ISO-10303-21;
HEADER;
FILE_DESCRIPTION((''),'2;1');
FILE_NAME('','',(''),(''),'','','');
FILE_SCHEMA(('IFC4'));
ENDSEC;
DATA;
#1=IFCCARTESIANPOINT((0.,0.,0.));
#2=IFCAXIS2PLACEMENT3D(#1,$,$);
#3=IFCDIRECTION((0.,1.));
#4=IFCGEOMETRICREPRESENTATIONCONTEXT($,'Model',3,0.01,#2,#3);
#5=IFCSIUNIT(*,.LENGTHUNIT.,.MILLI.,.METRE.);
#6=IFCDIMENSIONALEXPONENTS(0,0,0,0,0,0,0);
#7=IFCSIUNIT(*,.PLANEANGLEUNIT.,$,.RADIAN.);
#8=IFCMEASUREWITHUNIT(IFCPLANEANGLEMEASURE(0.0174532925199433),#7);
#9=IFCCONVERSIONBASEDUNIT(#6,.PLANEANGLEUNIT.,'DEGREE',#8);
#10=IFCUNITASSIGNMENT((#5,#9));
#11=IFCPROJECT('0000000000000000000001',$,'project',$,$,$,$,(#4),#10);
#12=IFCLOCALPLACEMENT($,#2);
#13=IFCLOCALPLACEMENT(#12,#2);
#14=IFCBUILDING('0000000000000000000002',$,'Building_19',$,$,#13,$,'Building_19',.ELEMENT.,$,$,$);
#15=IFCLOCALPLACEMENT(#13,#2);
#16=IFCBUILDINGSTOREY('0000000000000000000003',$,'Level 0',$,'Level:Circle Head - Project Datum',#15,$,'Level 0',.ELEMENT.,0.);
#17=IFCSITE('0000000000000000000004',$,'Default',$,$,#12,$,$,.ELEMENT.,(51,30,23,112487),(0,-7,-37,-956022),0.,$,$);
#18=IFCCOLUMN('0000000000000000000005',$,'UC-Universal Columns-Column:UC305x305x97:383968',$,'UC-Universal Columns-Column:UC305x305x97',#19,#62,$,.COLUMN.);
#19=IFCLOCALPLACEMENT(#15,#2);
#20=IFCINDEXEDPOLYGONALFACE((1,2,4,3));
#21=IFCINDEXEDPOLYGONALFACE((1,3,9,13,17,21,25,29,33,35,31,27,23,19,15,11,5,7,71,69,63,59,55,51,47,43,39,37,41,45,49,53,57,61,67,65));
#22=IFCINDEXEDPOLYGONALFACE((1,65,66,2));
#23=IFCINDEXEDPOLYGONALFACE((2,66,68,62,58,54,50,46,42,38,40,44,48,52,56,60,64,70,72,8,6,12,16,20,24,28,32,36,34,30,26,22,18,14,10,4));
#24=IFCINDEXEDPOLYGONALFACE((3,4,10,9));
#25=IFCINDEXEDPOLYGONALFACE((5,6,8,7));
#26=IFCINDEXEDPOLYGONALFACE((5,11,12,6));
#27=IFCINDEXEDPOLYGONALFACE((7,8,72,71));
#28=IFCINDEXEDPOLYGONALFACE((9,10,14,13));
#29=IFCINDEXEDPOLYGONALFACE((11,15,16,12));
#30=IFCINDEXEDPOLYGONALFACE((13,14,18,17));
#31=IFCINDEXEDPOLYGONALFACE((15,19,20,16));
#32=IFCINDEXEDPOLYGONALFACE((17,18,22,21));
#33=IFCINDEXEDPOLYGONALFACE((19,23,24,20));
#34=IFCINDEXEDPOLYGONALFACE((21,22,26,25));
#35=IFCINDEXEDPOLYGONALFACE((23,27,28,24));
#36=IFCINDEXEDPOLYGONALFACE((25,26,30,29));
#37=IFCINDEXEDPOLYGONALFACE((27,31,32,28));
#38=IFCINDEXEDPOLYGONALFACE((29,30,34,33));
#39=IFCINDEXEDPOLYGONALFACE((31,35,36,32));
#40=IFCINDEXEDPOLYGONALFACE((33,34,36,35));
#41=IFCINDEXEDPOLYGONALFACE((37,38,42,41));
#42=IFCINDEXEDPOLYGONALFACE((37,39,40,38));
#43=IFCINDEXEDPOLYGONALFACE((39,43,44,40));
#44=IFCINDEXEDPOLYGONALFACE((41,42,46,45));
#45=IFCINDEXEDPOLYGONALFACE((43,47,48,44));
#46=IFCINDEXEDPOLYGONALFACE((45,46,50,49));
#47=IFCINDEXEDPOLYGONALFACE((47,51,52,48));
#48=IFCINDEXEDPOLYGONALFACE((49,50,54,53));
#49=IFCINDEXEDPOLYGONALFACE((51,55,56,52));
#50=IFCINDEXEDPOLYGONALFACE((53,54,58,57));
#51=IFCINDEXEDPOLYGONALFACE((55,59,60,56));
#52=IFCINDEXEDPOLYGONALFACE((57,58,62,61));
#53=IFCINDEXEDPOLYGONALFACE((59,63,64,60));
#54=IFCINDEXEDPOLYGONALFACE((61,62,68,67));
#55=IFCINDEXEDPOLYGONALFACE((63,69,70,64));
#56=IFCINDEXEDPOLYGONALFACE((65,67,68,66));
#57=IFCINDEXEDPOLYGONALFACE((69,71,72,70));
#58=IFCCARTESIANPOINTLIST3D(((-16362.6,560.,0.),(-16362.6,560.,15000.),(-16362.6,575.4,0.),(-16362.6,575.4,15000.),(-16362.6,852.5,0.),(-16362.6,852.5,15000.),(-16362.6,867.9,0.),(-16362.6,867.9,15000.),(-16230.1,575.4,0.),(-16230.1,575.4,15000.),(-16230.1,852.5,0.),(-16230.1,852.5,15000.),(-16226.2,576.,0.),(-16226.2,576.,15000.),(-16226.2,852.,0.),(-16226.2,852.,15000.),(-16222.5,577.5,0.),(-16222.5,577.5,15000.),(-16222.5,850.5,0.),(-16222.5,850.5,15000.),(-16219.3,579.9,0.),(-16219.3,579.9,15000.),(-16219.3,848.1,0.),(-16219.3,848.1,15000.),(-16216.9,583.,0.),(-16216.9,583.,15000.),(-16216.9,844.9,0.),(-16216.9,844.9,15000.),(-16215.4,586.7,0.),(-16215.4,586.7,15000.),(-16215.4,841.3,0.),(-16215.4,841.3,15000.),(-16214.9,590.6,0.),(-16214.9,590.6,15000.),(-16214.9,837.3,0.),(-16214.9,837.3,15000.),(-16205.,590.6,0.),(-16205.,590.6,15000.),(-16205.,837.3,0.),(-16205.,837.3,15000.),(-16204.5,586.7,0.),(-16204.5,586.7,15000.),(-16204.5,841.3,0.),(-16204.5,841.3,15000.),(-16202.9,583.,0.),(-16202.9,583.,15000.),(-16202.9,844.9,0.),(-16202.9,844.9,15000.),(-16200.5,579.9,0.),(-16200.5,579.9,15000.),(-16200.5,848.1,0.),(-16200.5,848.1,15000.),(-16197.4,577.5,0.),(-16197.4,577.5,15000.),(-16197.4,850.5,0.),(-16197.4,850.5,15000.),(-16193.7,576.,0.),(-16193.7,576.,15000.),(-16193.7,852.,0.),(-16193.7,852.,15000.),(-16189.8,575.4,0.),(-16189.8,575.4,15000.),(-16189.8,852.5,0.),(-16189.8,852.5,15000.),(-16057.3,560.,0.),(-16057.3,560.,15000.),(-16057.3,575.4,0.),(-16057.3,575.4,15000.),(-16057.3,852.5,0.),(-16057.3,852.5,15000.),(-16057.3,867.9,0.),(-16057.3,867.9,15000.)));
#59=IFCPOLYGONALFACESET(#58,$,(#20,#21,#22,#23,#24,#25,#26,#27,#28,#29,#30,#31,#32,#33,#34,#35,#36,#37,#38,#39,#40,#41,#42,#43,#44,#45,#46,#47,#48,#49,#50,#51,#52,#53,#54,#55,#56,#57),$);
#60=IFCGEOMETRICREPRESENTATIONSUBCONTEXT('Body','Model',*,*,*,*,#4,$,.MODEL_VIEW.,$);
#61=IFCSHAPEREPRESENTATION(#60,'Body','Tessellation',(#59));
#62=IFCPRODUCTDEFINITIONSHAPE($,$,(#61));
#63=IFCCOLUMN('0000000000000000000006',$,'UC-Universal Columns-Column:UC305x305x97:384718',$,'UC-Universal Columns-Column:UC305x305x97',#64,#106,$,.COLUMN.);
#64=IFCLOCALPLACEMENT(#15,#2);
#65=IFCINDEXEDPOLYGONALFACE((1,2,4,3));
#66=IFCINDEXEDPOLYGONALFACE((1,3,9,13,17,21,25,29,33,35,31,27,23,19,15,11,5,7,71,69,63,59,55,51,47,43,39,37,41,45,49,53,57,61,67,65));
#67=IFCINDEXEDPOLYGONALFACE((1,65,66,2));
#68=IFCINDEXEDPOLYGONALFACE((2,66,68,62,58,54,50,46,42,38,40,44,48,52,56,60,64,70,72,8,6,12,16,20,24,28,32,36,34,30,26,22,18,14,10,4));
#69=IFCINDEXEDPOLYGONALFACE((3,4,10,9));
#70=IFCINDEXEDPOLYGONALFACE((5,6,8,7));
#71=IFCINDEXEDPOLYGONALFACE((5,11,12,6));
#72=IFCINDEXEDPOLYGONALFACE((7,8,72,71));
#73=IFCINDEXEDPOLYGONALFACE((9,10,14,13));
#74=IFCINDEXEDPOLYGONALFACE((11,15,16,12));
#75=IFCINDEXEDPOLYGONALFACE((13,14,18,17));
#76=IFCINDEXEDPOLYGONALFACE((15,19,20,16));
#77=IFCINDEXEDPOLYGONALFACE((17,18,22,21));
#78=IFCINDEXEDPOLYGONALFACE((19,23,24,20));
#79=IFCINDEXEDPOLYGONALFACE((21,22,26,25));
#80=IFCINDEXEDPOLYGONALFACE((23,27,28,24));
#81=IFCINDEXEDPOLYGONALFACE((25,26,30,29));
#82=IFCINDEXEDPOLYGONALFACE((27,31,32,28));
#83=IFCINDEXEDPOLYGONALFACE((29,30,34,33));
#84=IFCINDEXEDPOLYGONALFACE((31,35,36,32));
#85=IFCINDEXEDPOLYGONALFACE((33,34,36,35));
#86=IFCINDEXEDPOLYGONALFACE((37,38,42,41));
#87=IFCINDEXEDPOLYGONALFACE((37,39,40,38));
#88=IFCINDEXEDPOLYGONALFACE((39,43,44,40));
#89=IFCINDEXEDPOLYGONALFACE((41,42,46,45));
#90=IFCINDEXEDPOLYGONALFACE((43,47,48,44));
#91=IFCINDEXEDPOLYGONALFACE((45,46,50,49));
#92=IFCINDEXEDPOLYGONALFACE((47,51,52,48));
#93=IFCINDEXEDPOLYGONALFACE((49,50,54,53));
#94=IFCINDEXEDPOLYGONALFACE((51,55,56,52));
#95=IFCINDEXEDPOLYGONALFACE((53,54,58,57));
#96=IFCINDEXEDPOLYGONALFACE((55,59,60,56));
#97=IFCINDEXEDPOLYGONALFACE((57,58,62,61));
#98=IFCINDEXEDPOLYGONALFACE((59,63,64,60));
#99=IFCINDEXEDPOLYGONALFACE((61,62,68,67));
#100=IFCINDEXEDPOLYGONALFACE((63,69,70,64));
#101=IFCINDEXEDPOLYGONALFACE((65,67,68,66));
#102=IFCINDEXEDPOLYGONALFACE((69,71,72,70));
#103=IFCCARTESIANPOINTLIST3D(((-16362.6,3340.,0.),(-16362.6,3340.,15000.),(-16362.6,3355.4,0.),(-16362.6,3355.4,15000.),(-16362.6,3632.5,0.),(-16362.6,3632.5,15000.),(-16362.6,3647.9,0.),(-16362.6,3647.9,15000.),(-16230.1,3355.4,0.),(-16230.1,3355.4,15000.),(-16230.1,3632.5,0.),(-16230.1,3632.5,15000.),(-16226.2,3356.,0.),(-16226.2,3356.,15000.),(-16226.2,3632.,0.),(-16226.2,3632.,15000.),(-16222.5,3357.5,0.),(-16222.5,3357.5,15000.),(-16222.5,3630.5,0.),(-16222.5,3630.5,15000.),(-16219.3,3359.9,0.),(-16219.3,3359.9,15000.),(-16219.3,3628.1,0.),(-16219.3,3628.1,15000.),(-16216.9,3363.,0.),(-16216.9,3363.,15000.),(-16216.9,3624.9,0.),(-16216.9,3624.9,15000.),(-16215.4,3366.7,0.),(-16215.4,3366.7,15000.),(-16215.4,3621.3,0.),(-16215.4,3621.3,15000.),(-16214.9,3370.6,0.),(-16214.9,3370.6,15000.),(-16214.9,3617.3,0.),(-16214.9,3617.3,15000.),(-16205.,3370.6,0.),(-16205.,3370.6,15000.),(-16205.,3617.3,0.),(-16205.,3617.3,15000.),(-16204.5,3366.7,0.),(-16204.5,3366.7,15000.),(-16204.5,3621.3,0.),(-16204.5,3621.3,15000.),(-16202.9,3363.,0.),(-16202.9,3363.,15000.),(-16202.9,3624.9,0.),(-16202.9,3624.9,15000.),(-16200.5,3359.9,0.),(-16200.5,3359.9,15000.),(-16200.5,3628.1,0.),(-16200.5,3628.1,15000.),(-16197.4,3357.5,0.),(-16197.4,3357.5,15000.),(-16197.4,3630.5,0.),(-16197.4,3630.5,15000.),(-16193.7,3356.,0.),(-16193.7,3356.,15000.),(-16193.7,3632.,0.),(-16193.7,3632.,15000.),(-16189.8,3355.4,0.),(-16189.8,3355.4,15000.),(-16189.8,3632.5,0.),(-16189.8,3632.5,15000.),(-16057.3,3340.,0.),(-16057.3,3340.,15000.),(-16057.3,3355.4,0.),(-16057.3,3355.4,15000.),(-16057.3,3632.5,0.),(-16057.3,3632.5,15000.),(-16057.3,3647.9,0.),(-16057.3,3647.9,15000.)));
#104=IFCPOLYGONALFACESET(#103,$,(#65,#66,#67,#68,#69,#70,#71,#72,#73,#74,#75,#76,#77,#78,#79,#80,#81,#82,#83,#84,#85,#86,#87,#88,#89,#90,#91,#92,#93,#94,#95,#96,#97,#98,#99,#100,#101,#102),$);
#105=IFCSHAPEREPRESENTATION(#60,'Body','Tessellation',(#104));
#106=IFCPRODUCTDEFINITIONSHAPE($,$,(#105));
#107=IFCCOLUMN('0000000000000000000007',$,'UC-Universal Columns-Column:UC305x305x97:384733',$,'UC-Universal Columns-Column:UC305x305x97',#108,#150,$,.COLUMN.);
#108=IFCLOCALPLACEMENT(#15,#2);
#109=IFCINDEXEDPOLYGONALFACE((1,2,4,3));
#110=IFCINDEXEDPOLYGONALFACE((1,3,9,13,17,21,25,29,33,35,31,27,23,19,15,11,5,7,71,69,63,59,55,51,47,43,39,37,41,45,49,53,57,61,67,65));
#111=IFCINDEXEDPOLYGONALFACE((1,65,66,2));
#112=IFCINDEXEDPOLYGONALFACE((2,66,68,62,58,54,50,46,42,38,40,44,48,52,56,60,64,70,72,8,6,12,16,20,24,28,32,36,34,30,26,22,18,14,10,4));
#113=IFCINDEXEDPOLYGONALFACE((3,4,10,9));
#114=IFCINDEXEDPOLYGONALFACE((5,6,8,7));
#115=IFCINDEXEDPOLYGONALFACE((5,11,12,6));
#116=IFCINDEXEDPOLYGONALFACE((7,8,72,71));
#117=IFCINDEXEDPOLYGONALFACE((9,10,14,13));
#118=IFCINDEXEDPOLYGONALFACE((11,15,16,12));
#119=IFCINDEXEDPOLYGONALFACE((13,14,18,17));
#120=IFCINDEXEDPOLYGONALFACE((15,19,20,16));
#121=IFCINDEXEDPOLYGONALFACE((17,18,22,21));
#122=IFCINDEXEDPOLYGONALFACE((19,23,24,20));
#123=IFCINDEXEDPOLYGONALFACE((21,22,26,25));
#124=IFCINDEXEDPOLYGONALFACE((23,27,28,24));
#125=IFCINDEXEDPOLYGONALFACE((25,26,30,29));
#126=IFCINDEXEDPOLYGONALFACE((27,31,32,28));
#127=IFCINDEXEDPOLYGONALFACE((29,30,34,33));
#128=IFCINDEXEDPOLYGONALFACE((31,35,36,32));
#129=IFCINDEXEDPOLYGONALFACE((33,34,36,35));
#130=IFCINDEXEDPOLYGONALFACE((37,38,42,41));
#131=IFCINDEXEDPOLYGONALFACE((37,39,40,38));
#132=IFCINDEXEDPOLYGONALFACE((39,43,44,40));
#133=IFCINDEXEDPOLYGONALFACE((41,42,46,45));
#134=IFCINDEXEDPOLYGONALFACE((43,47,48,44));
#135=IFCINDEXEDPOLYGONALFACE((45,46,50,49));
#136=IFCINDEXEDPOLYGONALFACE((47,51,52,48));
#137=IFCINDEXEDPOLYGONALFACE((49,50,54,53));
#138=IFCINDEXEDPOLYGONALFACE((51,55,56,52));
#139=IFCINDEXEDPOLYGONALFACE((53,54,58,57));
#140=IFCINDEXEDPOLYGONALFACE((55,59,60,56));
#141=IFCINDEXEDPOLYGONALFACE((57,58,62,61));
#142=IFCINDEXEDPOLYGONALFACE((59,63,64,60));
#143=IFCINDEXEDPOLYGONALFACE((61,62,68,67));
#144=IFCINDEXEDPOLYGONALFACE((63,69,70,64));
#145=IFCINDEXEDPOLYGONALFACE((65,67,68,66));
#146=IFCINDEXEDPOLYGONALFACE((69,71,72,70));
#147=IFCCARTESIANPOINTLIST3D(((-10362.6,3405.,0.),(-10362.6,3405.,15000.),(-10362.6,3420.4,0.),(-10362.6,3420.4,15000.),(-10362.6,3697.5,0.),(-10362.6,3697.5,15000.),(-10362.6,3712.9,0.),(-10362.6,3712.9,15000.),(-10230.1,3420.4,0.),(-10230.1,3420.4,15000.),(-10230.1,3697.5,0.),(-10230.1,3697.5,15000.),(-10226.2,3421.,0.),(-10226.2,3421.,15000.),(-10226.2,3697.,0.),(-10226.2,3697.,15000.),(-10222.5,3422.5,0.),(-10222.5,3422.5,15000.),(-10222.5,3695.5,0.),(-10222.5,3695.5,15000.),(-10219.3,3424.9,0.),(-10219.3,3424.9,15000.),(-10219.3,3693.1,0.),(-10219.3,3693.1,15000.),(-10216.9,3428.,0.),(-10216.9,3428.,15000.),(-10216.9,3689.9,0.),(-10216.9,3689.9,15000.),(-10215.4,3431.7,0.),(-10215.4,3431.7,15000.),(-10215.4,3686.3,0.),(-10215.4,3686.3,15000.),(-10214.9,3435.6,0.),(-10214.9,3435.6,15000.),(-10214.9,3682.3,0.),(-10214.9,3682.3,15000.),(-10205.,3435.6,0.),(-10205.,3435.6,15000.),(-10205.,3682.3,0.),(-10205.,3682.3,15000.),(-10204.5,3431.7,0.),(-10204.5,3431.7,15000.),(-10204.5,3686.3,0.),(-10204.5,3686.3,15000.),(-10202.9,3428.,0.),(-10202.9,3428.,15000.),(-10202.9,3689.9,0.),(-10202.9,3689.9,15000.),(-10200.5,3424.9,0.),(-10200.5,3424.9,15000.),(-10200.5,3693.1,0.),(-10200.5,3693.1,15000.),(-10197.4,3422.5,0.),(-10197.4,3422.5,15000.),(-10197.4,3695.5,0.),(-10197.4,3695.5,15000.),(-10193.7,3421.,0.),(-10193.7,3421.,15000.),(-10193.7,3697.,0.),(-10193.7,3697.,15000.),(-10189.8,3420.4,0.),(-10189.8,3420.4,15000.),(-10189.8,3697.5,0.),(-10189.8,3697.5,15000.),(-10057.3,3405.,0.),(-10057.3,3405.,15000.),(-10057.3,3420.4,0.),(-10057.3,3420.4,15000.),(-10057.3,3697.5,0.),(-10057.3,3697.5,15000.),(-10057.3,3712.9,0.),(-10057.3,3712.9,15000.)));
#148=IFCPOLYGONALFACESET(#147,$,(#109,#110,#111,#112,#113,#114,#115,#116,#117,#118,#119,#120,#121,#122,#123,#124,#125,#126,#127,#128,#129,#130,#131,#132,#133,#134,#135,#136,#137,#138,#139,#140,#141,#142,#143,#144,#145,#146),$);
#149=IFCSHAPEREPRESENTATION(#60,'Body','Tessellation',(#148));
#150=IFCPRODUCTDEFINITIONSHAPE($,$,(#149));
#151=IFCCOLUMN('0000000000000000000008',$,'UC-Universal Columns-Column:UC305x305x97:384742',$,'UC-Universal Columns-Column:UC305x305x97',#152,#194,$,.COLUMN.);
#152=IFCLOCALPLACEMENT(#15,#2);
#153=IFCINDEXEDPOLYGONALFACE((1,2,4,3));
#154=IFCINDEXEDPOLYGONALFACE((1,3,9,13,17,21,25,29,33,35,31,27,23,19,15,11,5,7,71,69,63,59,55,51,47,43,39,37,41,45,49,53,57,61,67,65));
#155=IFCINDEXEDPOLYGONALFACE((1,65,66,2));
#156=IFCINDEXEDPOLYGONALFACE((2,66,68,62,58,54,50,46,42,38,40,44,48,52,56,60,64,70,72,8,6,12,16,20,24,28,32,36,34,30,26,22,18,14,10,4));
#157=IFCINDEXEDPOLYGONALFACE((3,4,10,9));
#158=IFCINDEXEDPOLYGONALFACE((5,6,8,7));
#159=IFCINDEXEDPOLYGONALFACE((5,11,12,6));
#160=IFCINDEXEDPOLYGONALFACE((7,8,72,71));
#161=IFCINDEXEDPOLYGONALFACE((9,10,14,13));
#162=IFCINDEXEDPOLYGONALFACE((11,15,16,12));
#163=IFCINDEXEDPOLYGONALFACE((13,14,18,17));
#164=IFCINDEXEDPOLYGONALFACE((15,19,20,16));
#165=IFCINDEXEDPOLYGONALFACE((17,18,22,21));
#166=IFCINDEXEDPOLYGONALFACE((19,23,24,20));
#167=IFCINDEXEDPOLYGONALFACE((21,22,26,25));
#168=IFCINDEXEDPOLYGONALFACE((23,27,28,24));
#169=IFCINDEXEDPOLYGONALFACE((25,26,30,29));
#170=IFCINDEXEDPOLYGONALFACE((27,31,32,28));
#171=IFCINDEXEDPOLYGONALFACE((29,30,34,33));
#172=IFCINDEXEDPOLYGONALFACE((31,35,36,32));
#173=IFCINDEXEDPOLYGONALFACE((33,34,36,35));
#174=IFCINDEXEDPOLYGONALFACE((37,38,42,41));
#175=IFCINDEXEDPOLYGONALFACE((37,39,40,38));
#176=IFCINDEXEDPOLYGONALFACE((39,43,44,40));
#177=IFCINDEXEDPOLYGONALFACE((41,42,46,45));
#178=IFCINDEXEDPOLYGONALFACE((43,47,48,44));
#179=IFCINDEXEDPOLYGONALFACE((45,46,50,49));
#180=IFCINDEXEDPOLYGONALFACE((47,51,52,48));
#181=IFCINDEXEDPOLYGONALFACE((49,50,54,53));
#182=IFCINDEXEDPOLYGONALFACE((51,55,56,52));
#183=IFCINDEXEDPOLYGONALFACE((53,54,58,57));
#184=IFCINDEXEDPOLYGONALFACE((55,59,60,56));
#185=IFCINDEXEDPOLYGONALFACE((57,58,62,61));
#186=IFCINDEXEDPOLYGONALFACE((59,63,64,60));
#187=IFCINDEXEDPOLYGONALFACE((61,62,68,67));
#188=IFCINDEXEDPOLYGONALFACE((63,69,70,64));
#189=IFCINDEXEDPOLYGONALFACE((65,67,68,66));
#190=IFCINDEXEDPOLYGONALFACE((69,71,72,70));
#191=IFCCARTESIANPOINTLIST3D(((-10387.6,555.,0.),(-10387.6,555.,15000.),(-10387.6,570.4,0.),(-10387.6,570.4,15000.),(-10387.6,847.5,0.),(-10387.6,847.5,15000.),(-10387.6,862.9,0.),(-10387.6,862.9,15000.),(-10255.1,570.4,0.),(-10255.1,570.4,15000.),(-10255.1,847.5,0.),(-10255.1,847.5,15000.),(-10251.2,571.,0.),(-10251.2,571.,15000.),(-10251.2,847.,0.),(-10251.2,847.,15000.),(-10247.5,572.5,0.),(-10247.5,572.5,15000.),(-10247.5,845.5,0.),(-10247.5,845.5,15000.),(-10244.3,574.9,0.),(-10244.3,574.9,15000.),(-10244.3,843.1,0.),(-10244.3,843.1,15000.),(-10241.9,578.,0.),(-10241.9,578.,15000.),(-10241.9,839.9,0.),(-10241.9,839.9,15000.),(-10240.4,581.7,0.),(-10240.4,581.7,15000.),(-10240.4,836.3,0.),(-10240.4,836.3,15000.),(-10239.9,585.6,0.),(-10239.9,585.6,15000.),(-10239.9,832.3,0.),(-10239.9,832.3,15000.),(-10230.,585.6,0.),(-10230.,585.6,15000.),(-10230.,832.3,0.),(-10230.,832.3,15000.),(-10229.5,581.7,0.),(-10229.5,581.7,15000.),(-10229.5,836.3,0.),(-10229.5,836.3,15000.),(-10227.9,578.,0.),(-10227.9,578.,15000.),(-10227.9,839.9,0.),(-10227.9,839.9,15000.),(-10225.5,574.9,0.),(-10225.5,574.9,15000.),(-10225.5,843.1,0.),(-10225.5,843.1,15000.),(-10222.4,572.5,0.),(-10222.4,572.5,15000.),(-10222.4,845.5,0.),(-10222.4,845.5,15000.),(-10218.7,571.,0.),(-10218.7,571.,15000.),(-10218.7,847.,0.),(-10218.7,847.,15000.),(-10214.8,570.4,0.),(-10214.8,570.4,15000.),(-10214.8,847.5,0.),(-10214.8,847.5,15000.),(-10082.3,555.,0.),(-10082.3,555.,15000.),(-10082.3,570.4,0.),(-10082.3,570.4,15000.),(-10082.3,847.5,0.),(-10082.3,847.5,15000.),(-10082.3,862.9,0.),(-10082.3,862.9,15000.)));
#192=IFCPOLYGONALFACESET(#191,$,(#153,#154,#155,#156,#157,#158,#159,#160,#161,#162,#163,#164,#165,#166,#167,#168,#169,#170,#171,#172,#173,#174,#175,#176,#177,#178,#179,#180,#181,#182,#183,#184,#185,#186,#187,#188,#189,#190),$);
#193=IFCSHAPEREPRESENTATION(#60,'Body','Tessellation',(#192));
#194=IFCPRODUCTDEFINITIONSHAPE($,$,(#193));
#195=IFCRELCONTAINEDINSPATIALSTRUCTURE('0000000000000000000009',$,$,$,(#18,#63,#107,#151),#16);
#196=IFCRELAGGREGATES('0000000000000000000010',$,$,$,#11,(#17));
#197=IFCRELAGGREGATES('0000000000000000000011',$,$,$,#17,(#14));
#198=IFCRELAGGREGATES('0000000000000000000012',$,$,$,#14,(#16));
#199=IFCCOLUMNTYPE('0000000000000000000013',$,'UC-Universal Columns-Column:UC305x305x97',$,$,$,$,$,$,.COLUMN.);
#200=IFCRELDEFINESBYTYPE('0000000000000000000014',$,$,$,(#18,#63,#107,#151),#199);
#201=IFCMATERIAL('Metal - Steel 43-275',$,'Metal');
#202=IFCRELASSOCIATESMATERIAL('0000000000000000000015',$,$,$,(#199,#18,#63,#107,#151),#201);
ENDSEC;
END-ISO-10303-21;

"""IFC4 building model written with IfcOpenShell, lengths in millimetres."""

from ifc_helpers import new_model, entity, si_unit, converted_unit, direction, frame, origin, place, context, subcontext, project, spatial, line, arc, indexed_curve, outline, extrude, source, transform, mapped, material, type_object, type_shapes, element, save


model = new_model("IFC4")

# Units and contexts
model_context = context("Model", 3, precision=0.01, world=origin(), true_north=direction((0.0, 1.0)))
body_context = subcontext(model_context, "Body", "Model", "MODEL_VIEW")
ifc_project = project(units=[si_unit("LENGTHUNIT", "METRE", prefix="MILLI"), converted_unit("PLANEANGLEUNIT", "DEGREE", entity("IfcPlaneAngleMeasure", 0.0174532925199433), si_unit("PLANEANGLEUNIT", "RADIAN"), dimensions=[0, 0, 0, 0, 0, 0, 0])], contexts=[model_context])

# Site, building, storey
site_placement = place(None, origin())
site = spatial("IfcSite", under=ifc_project, at=site_placement, Name="Default", CompositionType="ELEMENT", RefLatitude=(51, 30, 23, 112487), RefLongitude=(0, -7, -37, -956022), RefElevation=0.0)
building_placement = place(site_placement, origin())
building = spatial("IfcBuilding", under=site, at=building_placement, Name="Building_19", LongName="Building_19", CompositionType="ELEMENT")
storey_placement = place(building_placement, origin())
storey = spatial("IfcBuildingStorey", under=building, at=storey_placement, Name="Level 0", ObjectType="Level:Circle Head - Project Datum", LongName="Level 0", CompositionType="ELEMENT", Elevation=0.0)

# Columns
ifc_material_1 = material(Name="Metal - Steel 43-275", Category="Metal")
column_type = type_object("IfcColumnType", Name="UC-Universal Columns-Column:UC305x305x97", PredefinedType="COLUMN", material=ifc_material_1)
shared_shape_1 = source(origin(), body_context, "Body", "SweptSolid", [
    extrude(outline(indexed_curve([(-152.7, -153.9), (152.7, -153.9), (152.7, -138.6), (20.2, -138.6), (9.4, -134.1), (4.9, -123.3), (4.9, 123.3), (9.4, 134.1), (20.1, 138.6), (152.7, 138.6), (152.7, 153.9), (-152.7, 153.9), (-152.7, 138.6), (-20.2, 138.6), (-9.4, 134.1), (-5.0, 123.3), (-5.0, -123.3), (-9.4, -134.1), (-20.2, -138.6), (-152.7, -138.6)], segments=[line(1, 2, 3, 4), arc(4, 5, 6), line(6, 7), arc(7, 8, 9), line(9, 10, 11, 12, 13, 14), arc(14, 15, 16), line(16, 17), arc(17, 18, 19), line(19, 20, 1)], self_intersect=False)), frame((0.0, 0.0, 0.0), z_axis=(0.0, 0.0, 1.0), x_axis=(-1.0, 0.0, 0.0)), (0.0, 0.0, 1.0), 15000.0),
])
type_shapes(column_type, [shared_shape_1])
for number, where, name in (
    (1, (-16209.9, 714.0, 0.0), "UC-Universal Columns-Column:UC305x305x97:383968"),
    (2, (-16209.9, 3494.0, 0.0), "UC-Universal Columns-Column:UC305x305x97:384718"),
    (3, (-10209.9, 3559.0, 0.0), "UC-Universal Columns-Column:UC305x305x97:384733"),
    (4, (-10234.9, 709.0, 0.0), "UC-Universal Columns-Column:UC305x305x97:384742"),
):
    element("IfcColumn", number, at=place(storey_placement, frame(where)), inside=storey, type_object=column_type, material=ifc_material_1, Name=name, ObjectType="UC-Universal Columns-Column:UC305x305x97", PredefinedType="COLUMN", context=body_context, shape_type="MappedRepresentation", body=[
        mapped(shared_shape_1, transform((0.0, 0.0, 0.0), scale=1.0)),
    ])

save(model, "model.ifc")
